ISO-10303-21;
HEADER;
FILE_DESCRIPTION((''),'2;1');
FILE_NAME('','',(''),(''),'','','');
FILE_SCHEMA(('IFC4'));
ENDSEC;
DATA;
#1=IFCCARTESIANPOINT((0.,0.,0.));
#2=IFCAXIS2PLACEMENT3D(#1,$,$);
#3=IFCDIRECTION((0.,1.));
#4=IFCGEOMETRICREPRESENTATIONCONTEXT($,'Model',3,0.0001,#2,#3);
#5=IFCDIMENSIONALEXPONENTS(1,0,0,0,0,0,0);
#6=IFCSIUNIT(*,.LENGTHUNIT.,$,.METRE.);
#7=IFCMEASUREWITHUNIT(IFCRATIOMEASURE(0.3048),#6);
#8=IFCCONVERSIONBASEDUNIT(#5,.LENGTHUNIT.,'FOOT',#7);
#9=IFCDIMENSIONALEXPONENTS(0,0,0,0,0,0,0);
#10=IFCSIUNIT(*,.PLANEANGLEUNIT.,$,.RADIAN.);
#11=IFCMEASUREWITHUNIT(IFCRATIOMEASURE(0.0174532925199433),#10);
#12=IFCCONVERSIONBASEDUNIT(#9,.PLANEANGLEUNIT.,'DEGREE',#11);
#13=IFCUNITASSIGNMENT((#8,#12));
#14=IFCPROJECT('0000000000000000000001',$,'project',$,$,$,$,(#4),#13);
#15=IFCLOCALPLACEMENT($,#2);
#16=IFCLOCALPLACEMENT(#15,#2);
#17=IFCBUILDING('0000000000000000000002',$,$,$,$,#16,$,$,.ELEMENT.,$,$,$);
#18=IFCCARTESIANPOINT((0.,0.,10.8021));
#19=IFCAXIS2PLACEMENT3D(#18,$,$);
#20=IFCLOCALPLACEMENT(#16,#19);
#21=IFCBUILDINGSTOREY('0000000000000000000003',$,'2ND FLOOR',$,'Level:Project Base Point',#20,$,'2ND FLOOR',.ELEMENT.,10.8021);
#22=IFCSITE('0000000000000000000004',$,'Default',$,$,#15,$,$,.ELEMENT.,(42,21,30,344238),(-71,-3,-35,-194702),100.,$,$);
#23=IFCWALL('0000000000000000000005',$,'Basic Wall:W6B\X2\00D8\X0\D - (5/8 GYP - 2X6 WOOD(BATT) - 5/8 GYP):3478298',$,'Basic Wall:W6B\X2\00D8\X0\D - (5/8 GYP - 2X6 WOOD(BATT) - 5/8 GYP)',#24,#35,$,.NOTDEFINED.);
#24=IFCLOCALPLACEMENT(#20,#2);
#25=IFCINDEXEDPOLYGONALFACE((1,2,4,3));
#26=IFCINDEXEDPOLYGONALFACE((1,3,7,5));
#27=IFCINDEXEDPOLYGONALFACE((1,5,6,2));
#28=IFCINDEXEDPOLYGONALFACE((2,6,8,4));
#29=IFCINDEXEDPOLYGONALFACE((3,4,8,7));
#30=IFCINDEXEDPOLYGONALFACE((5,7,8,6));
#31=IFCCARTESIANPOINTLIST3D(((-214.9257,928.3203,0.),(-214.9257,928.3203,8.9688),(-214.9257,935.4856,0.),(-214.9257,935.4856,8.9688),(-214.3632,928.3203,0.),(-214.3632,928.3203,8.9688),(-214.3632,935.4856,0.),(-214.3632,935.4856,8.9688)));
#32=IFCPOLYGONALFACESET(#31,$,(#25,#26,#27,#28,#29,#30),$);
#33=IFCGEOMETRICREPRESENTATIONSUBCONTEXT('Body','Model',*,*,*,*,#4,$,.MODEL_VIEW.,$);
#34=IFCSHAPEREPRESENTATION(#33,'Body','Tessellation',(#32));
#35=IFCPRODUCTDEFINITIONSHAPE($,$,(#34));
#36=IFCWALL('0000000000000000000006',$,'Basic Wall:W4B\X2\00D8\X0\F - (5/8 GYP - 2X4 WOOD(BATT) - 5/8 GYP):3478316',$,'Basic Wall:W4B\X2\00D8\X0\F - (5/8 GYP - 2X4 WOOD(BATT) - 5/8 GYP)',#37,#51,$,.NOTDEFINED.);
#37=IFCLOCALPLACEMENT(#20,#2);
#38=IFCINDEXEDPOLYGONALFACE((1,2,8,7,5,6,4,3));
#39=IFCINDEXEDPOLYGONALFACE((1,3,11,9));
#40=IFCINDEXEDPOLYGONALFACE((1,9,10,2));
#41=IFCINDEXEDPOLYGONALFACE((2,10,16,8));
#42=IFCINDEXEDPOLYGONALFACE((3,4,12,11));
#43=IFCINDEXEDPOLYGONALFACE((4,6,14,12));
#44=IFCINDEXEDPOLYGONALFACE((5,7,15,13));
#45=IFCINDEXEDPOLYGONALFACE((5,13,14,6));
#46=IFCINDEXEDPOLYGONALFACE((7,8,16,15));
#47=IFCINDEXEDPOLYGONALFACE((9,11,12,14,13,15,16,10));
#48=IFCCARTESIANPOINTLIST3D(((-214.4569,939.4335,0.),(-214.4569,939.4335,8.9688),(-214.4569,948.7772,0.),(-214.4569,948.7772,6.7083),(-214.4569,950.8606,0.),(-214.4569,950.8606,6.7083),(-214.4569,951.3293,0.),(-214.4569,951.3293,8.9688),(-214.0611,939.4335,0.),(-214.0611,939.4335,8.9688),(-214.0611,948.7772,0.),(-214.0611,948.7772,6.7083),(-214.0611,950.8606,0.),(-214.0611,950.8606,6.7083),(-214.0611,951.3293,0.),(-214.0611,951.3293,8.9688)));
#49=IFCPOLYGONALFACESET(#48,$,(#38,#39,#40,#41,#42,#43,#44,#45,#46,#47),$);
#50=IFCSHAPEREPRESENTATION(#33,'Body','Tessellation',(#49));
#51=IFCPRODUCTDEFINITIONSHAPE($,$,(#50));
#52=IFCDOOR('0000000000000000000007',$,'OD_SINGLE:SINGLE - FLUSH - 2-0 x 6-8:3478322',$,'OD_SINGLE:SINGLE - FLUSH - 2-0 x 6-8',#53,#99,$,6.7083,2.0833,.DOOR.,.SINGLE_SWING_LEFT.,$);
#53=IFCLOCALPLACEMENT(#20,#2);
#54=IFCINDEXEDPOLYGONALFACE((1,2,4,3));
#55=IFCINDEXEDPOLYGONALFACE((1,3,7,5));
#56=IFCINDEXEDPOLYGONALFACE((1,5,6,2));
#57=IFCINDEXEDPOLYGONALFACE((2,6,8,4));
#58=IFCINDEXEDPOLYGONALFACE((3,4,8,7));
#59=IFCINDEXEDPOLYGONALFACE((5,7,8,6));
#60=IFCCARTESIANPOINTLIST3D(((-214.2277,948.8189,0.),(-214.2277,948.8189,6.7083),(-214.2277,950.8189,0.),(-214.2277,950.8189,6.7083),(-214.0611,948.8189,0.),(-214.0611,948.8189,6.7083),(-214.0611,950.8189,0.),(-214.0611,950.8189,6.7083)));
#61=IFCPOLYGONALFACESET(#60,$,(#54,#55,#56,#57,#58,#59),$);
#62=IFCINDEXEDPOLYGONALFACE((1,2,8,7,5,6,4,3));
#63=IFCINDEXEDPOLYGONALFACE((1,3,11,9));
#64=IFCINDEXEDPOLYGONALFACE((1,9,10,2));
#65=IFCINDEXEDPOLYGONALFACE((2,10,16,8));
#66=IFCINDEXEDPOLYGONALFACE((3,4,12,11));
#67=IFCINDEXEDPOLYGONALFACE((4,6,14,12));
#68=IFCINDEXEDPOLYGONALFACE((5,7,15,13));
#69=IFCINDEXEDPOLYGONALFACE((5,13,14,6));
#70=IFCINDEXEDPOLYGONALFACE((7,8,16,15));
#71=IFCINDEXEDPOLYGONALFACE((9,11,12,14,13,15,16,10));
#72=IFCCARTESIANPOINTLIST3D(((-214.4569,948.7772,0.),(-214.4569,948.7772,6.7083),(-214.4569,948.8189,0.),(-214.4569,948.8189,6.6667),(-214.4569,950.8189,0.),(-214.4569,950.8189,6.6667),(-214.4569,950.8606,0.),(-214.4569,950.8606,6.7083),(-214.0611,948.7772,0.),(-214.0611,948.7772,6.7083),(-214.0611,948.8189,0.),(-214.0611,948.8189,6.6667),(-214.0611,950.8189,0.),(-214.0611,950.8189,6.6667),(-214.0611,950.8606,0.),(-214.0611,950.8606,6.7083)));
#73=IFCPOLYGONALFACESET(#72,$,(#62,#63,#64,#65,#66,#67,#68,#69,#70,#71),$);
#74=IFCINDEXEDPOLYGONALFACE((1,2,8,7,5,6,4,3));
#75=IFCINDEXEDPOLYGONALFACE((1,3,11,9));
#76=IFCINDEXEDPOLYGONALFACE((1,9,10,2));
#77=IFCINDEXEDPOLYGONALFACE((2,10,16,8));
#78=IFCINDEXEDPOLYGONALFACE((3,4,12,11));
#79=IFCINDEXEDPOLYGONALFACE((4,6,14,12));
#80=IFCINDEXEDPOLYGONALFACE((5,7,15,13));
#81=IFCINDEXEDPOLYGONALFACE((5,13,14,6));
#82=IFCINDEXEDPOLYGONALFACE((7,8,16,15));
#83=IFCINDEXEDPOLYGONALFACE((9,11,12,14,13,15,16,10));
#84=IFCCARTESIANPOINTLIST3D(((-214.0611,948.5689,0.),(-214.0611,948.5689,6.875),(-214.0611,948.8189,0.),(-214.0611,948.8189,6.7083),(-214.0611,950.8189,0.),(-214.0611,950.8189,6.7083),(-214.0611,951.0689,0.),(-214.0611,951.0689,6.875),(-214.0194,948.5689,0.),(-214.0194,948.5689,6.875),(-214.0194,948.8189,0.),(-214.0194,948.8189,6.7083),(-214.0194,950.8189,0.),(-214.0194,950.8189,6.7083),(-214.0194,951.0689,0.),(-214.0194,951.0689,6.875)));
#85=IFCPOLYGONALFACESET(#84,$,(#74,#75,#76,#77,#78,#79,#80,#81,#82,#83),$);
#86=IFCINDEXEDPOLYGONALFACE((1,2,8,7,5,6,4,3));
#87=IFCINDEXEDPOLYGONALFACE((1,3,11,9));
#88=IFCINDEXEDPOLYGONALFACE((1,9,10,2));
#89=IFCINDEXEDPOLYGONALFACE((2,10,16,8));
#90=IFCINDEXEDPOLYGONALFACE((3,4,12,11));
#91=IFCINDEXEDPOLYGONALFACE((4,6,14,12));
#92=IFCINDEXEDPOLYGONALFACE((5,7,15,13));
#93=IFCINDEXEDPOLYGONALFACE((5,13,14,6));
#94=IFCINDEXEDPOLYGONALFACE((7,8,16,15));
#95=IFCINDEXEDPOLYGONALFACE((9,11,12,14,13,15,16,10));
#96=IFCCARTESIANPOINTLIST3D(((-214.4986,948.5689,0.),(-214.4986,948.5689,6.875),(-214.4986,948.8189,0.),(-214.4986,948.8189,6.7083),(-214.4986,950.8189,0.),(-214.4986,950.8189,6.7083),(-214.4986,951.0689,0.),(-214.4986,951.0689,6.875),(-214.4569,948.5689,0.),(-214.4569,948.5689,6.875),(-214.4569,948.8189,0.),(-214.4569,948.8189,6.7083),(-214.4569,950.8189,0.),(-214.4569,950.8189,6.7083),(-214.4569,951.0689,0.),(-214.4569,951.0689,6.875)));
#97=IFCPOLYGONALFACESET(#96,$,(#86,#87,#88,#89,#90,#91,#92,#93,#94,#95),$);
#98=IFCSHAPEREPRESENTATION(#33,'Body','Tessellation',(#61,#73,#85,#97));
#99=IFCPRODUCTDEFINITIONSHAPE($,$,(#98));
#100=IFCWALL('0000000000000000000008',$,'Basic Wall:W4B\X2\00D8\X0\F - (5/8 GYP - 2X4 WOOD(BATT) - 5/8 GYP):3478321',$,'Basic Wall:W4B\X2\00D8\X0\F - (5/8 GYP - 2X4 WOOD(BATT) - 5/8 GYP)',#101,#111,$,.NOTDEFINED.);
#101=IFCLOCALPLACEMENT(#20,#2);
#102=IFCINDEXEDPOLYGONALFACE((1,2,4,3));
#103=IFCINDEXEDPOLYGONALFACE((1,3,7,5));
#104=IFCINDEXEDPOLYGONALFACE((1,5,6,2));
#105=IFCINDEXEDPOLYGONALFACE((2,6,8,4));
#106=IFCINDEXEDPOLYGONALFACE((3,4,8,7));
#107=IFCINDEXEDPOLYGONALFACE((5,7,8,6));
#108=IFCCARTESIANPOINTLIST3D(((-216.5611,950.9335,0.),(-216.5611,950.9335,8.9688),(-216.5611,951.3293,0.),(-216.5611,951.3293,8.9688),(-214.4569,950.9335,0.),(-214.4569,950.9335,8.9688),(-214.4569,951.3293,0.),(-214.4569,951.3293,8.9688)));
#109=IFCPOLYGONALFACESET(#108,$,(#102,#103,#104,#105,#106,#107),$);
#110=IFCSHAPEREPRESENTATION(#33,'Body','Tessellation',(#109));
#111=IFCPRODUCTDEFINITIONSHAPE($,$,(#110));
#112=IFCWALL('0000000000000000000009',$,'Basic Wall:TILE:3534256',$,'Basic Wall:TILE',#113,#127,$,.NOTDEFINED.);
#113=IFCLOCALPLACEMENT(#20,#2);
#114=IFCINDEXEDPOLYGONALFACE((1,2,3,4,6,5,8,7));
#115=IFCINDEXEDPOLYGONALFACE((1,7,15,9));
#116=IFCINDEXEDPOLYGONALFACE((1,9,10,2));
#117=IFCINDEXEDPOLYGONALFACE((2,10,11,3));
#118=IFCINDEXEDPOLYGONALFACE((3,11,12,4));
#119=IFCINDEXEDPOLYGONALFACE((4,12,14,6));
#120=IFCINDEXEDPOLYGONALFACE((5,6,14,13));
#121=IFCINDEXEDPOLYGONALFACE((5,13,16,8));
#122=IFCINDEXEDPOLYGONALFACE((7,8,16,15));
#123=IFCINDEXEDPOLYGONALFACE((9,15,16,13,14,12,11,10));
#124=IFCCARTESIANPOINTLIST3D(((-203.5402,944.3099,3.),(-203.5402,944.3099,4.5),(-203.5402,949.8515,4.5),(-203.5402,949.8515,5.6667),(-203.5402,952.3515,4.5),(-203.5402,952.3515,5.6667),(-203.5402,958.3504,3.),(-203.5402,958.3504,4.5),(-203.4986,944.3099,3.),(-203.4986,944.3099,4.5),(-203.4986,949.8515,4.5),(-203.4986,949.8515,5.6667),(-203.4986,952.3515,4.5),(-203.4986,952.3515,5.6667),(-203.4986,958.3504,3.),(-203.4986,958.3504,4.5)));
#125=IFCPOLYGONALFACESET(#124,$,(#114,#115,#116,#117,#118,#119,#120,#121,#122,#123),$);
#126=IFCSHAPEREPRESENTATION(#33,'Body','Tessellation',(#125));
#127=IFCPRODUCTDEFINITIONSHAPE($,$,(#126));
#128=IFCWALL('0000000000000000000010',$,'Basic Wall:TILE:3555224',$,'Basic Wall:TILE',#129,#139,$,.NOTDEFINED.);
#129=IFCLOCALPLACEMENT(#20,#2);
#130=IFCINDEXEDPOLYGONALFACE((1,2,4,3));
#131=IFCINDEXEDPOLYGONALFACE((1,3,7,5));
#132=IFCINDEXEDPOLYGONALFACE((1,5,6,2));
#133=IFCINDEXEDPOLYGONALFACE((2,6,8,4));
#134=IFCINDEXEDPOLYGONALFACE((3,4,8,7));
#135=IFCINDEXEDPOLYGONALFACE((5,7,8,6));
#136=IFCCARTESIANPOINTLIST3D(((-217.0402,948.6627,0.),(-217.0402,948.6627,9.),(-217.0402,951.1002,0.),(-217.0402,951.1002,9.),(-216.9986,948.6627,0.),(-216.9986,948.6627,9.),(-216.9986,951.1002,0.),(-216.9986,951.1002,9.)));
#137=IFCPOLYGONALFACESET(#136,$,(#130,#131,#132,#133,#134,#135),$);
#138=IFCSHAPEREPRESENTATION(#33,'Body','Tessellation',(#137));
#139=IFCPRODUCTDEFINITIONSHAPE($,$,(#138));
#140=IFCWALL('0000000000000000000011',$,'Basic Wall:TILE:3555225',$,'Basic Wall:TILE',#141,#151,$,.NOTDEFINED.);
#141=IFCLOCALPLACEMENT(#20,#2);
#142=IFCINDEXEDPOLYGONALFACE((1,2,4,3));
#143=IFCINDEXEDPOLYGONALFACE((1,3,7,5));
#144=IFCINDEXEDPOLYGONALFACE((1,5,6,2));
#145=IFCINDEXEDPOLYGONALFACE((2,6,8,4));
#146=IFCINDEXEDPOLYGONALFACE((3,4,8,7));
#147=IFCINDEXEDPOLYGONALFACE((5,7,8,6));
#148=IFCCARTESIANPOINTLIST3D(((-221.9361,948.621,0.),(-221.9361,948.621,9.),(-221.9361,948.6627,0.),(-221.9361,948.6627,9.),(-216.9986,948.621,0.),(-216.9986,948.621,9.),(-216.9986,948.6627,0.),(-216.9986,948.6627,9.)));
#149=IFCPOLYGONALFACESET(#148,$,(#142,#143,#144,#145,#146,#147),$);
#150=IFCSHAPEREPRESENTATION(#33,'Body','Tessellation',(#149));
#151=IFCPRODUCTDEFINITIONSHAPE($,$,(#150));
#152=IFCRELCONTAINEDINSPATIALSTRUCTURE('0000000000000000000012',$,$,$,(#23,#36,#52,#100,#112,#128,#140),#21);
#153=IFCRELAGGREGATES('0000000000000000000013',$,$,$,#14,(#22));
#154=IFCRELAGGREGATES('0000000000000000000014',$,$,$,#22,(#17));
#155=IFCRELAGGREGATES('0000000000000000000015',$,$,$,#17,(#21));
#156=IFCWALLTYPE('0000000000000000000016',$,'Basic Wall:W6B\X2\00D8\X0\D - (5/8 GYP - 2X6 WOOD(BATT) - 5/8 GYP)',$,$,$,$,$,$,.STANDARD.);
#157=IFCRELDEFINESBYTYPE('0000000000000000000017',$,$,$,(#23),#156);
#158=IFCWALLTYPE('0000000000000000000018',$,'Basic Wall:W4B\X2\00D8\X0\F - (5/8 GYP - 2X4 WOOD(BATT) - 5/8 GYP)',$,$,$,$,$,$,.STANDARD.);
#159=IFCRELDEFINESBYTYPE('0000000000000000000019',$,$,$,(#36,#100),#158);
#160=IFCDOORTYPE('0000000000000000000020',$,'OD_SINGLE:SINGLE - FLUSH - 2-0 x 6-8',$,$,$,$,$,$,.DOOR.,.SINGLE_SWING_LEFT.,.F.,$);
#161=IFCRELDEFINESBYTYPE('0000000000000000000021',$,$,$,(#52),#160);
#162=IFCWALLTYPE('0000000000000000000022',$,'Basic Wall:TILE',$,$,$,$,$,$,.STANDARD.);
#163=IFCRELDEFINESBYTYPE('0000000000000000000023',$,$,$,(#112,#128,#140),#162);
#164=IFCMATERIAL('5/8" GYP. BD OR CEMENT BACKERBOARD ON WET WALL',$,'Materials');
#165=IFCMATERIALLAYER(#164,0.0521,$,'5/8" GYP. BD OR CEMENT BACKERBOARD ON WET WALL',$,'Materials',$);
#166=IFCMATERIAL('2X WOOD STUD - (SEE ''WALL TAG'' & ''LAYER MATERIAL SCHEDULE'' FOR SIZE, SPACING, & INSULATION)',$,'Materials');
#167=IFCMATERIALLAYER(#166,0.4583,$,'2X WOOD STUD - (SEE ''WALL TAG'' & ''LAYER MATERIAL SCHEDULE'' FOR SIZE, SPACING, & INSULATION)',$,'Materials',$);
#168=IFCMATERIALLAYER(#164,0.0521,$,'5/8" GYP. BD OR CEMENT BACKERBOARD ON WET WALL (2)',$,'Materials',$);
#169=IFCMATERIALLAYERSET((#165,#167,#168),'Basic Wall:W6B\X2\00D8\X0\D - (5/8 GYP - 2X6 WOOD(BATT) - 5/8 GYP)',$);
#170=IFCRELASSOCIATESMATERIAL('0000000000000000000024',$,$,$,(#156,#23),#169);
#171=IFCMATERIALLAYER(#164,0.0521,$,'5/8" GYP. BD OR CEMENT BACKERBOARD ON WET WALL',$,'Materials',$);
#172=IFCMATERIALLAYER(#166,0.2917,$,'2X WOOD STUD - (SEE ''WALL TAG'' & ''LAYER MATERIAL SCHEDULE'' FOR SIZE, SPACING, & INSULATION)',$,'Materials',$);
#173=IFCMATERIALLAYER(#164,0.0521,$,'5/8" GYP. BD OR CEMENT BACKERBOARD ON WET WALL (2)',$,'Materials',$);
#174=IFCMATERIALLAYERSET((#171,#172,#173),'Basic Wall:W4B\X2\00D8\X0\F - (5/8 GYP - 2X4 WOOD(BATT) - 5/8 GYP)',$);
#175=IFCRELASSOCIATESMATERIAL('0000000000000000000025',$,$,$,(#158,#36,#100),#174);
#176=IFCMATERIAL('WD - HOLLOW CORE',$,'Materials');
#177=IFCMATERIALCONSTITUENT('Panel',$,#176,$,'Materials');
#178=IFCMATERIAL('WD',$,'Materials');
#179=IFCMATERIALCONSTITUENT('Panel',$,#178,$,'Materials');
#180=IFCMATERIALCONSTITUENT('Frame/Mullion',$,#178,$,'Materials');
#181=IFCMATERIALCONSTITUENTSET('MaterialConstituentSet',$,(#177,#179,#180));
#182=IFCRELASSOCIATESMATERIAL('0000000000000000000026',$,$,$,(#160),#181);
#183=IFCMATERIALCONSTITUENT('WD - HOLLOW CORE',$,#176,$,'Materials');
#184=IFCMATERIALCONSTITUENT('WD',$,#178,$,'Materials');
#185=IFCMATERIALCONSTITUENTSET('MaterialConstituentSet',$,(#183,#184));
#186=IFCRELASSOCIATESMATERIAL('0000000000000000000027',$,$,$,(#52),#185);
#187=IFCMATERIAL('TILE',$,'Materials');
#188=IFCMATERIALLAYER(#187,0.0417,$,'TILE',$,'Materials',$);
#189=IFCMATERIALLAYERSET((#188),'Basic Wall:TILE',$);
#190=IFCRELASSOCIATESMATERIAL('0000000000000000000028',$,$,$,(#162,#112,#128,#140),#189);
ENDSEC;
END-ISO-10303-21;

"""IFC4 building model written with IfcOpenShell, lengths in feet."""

from ifc_helpers import new_model, entity, si_unit, converted_unit, direction, frame, frame_2d, origin, origin_2d_with_axis, place, context, subcontext, project, spatial, polyline, rectangle, outline, extrude, source, transform, mapped, material, layer, layer_set, layer_usage, constituent, constituent_set, type_object, type_shapes, element, fill, save


model = new_model("IFC4")

# Units and contexts
model_context = context("Model", 3, precision=0.0001, world=origin(), true_north=direction((0.0, 1.0)))
body_context = subcontext(model_context, "Body", "Model", "MODEL_VIEW")
ifc_project = project(units=[converted_unit("LENGTHUNIT", "FOOT", entity("IfcRatioMeasure", 0.3048), si_unit("LENGTHUNIT", "METRE"), dimensions=[1, 0, 0, 0, 0, 0, 0]), converted_unit("PLANEANGLEUNIT", "DEGREE", entity("IfcRatioMeasure", 0.0174532925199433), si_unit("PLANEANGLEUNIT", "RADIAN"), dimensions=[0, 0, 0, 0, 0, 0, 0])], contexts=[model_context])

# Site, building, storey
site_placement = place(None, origin())
site = spatial("IfcSite", under=ifc_project, at=site_placement, Name="Default", CompositionType="ELEMENT", RefLatitude=(42, 21, 30, 344238), RefLongitude=(-71, -3, -35, -194702), RefElevation=100.0)
building_placement = place(site_placement, origin())
building = spatial("IfcBuilding", under=site, at=building_placement, CompositionType="ELEMENT")
storey_placement = place(building_placement, frame((0.0, 0.0, 10.8021)))
storey = spatial("IfcBuildingStorey", under=building, at=storey_placement, Name="2ND FLOOR", ObjectType="Level:Project Base Point", LongName="2ND FLOOR", CompositionType="ELEMENT", Elevation=10.8021)

# Wall
ifc_material_1 = material(Name="5/8\" GYP. BD OR CEMENT BACKERBOARD ON WET WALL", Category="Materials")
ifc_layer_1 = layer(ifc_material_1, 0.0521, Name="5/8\" GYP. BD OR CEMENT BACKERBOARD ON WET WALL", Category="Materials")
ifc_material_2 = material(Name="2X WOOD STUD - (SEE 'WALL TAG' & 'LAYER MATERIAL SCHEDULE' FOR SIZE, SPACING, & INSULATION)", Category="Materials")
ifc_layer_2 = layer(ifc_material_2, 0.4583, Name="2X WOOD STUD - (SEE 'WALL TAG' & 'LAYER MATERIAL SCHEDULE' FOR SIZE, SPACING, & INSULATION)", Category="Materials")
ifc_layer_3 = layer(ifc_material_1, 0.0521, Name="5/8\" GYP. BD OR CEMENT BACKERBOARD ON WET WALL (2)", Category="Materials")
ifc_layer_set_1 = layer_set([ifc_layer_1, ifc_layer_2, ifc_layer_3], Name="Basic Wall:W6BØD - (5/8 GYP - 2X6 WOOD(BATT) - 5/8 GYP)")
ifc_layer_usage_1 = layer_usage(ifc_layer_set_1, "AXIS2", "POSITIVE", -0.2812)
wall_type_1 = type_object("IfcWallType", Name="Basic Wall:W6BØD - (5/8 GYP - 2X6 WOOD(BATT) - 5/8 GYP)", PredefinedType="STANDARD", material=ifc_layer_set_1)
wall_1_placement = place(storey_placement, frame((-214.6444, 928.3203, 0.0), z_axis=(0.0, 0.0, 1.0), x_axis=(0.0, 1.0, 0.0)))
element("IfcWall", 1, at=wall_1_placement, inside=storey, type_object=wall_type_1, material=ifc_layer_usage_1, Name="Basic Wall:W6BØD - (5/8 GYP - 2X6 WOOD(BATT) - 5/8 GYP):3478298", ObjectType="Basic Wall:W6BØD - (5/8 GYP - 2X6 WOOD(BATT) - 5/8 GYP)", PredefinedType="NOTDEFINED", context=body_context, shape_type="SweptSolid", body=[
    extrude(rectangle(XDim=7.1653, YDim=0.5625, at=frame_2d((3.5826, 0.0), x_axis=(-1.0, 0.0))), origin(), (0.0, 0.0, 1.0), 8.9688),
])

# Wall, opening, door
ifc_layer_4 = layer(ifc_material_1, 0.0521, Name="5/8\" GYP. BD OR CEMENT BACKERBOARD ON WET WALL", Category="Materials")
ifc_layer_5 = layer(ifc_material_2, 0.2917, Name="2X WOOD STUD - (SEE 'WALL TAG' & 'LAYER MATERIAL SCHEDULE' FOR SIZE, SPACING, & INSULATION)", Category="Materials")
ifc_layer_6 = layer(ifc_material_1, 0.0521, Name="5/8\" GYP. BD OR CEMENT BACKERBOARD ON WET WALL (2)", Category="Materials")
ifc_layer_set_2 = layer_set([ifc_layer_4, ifc_layer_5, ifc_layer_6], Name="Basic Wall:W4BØF - (5/8 GYP - 2X4 WOOD(BATT) - 5/8 GYP)")
wall_type_2 = type_object("IfcWallType", Name="Basic Wall:W4BØF - (5/8 GYP - 2X4 WOOD(BATT) - 5/8 GYP)", PredefinedType="STANDARD", material=ifc_layer_set_2)
ifc_material_3 = material(Name="WD - HOLLOW CORE", Category="Materials")
ifc_material_4 = material(Name="WD", Category="Materials")
ifc_layer_usage_2 = layer_usage(ifc_layer_set_2, "AXIS2", "POSITIVE", -0.1979)
wall_2_placement = place(storey_placement, frame((-214.259, 939.4335, 0.0), z_axis=(0.0, 0.0, 1.0), x_axis=(0.0, 1.0, 0.0)))
wall_2 = element("IfcWall", 2, at=wall_2_placement, inside=storey, type_object=wall_type_2, material=ifc_layer_usage_2, Name="Basic Wall:W4BØF - (5/8 GYP - 2X4 WOOD(BATT) - 5/8 GYP):3478316", ObjectType="Basic Wall:W4BØF - (5/8 GYP - 2X4 WOOD(BATT) - 5/8 GYP)", PredefinedType="NOTDEFINED", context=body_context, shape_type="SweptSolid", body=[
    extrude(rectangle(XDim=11.8958, YDim=0.3958, at=frame_2d((5.9479, 0.0), x_axis=(-1.0, 0.0))), origin(), (0.0, 0.0, 1.0), 8.9688),
])
opening_1_placement = place(wall_2_placement, frame((11.4271, 0.1979, 0.0)))
opening_1 = element("IfcOpeningElement", 3, at=opening_1_placement, cuts=wall_2, PredefinedType="OPENING", context=body_context, shape_type="SweptSolid", body=[
    extrude(rectangle(XDim=2.0833, YDim=6.7083, at=frame_2d((3.3542, 1.0417), x_axis=(0.0, -1.0))), frame((0.0, 0.0, 0.0), z_axis=(0.0, -1.0, 0.0), x_axis=(0.0, 0.0, 1.0)), (0.0, 0.0, 1.0), 0.3958),
])
ifc_constituent_1 = constituent(ifc_material_3, Name="WD - HOLLOW CORE", Category="Materials")
ifc_constituent_2 = constituent(ifc_material_4, Name="WD", Category="Materials")
ifc_constituent_set_1 = constituent_set(constituents=[ifc_constituent_1, ifc_constituent_2], Name="MaterialConstituentSet")
ifc_constituent_3 = constituent(ifc_material_3, Name="Panel", Category="Materials")
ifc_constituent_4 = constituent(ifc_material_4, Name="Panel", Category="Materials")
ifc_constituent_5 = constituent(ifc_material_4, Name="Frame/Mullion", Category="Materials")
ifc_constituent_set_2 = constituent_set(constituents=[ifc_constituent_3, ifc_constituent_4, ifc_constituent_5], Name="MaterialConstituentSet")
door_type_1 = type_object("IfcDoorType", Name="OD_SINGLE:SINGLE - FLUSH - 2-0 x 6-8", OperationType="SINGLE_SWING_LEFT", ParameterTakesPrecedence=False, PredefinedType="DOOR", material=ifc_constituent_set_2)
shared_shape_1 = source(origin(), body_context, "Body", "SweptSolid", [
    extrude(rectangle(XDim=2.0, YDim=0.1667, at=origin_2d_with_axis()), frame((1.0417, 0.3125, 0.0)), (0.0, 0.0, 1.0), 6.7083),
    extrude(outline(polyline([(-3.3646, -1.0417), (3.3438, -1.0417), (3.3438, -1.0), (-3.3229, -1.0), (-3.3229, 1.0), (3.3438, 1.0), (3.3438, 1.0417), (-3.3646, 1.0417), (-3.3646, -1.0417)])), frame((1.0417, 0.3958, 3.3438), z_axis=(0.0, -1.0, 0.0), x_axis=(0.0, 0.0, -1.0)), (0.0, 0.0, 1.0), 0.3958),
    extrude(outline(polyline([(-1.25, -3.4792), (1.25, -3.4792), (1.25, 3.3958), (1.0, 3.3958), (1.0, -3.3125), (-1.0, -3.3125), (-1.0, 3.3958), (-1.25, 3.3958), (-1.25, -3.4792)])), frame((1.0417, 0.4375, 3.3958), z_axis=(0.0, -1.0, 0.0), x_axis=(-1.0, 0.0, 0.0)), (0.0, 0.0, 1.0), 0.0417),
    extrude(outline(polyline([(-3.4792, -1.25), (3.3958, -1.25), (3.3958, -1.0), (-3.3125, -1.0), (-3.3125, 1.0), (3.3958, 1.0), (3.3958, 1.25), (-3.4792, 1.25), (-3.4792, -1.25)])), frame((1.0417, 0.0, 3.3958), z_axis=(0.0, -1.0, 0.0), x_axis=(0.0, 0.0, -1.0)), (0.0, 0.0, 1.0), 0.0417),
])
type_shapes(door_type_1, [shared_shape_1])
door_1_placement = place(opening_1_placement, frame((0.0, 0.0, 0.0), z_axis=(0.0, 0.0, 1.0), x_axis=(-1.0, 0.0, 0.0)))
door_1 = element("IfcDoor", 4, at=door_1_placement, inside=storey, type_object=door_type_1, material=ifc_constituent_set_1, Name="OD_SINGLE:SINGLE - FLUSH - 2-0 x 6-8:3478322", ObjectType="OD_SINGLE:SINGLE - FLUSH - 2-0 x 6-8", OperationType="SINGLE_SWING_LEFT", OverallHeight=6.7083, OverallWidth=2.0833, PredefinedType="DOOR", context=body_context, shape_type="MappedRepresentation", body=[
    mapped(shared_shape_1, transform((0.0, 0.0, 0.0), scale=1.0)),
])
fill(opening_1, door_1)

# Wall
ifc_layer_usage_3 = layer_usage(ifc_layer_set_2, "AXIS2", "NEGATIVE", 0.1979)
wall_3_placement = place(storey_placement, frame((-216.5611, 951.1314, 0.0)))
element("IfcWall", 5, at=wall_3_placement, inside=storey, type_object=wall_type_2, material=ifc_layer_usage_3, Name="Basic Wall:W4BØF - (5/8 GYP - 2X4 WOOD(BATT) - 5/8 GYP):3478321", ObjectType="Basic Wall:W4BØF - (5/8 GYP - 2X4 WOOD(BATT) - 5/8 GYP)", PredefinedType="NOTDEFINED", context=body_context, shape_type="SweptSolid", body=[
    extrude(rectangle(XDim=2.1042, YDim=0.3958, at=frame_2d((1.0521, 0.0), x_axis=(-1.0, 0.0))), origin(), (0.0, 0.0, 1.0), 8.9688),
])

# Wall, openings
ifc_material_5 = material(Name="TILE", Category="Materials")
ifc_layer_7 = layer(ifc_material_5, 0.0417, Name="TILE", Category="Materials")
ifc_layer_set_3 = layer_set([ifc_layer_7], Name="Basic Wall:TILE")
ifc_layer_usage_4 = layer_usage(ifc_layer_set_3, "AXIS2", "NEGATIVE", 0.0208)
wall_type_3 = type_object("IfcWallType", Name="Basic Wall:TILE", PredefinedType="STANDARD", material=ifc_layer_set_3)
wall_4_placement = place(storey_placement, frame((-203.5194, 958.3504, 3.0), z_axis=(0.0, 0.0, 1.0), x_axis=(0.0, -1.0, 0.0)))
wall_4 = element("IfcWall", 6, at=wall_4_placement, inside=storey, type_object=wall_type_3, material=ifc_layer_usage_4, Name="Basic Wall:TILE:3534256", ObjectType="Basic Wall:TILE", PredefinedType="NOTDEFINED", context=body_context, shape_type="SweptSolid", body=[
    extrude(rectangle(XDim=14.0406, YDim=0.0417, at=frame_2d((7.0203, 0.0), x_axis=(-1.0, 0.0))), origin(), (0.0, 0.0, 1.0), 2.6667),
])
opening_2_placement = place(wall_4_placement, origin())
element("IfcOpeningElement", 7, at=opening_2_placement, cuts=wall_4, PredefinedType="OPENING", context=body_context, shape_type="SweptSolid", body=[
    extrude(rectangle(XDim=1.1667, YDim=5.5417, at=frame_2d((0.0, 0.0), x_axis=(1.0, 0.0))), frame((11.2697, 0.0208, 2.0833), z_axis=(0.0, -1.0, 0.0), x_axis=(0.0, 0.0, 1.0)), (0.0, 0.0, 1.0), 0.0417),
])
opening_3_placement = place(wall_4_placement, origin())
element("IfcOpeningElement", 8, at=opening_3_placement, cuts=wall_4, PredefinedType="OPENING", context=body_context, shape_type="SweptSolid", body=[
    extrude(rectangle(XDim=1.1667, YDim=5.9989, at=frame_2d((0.0, 0.0), x_axis=(0.0, 1.0))), frame((2.9994, 0.0208, 2.0833), z_axis=(0.0, -1.0, 0.0), x_axis=(-1.0, 0.0, 0.0)), (0.0, 0.0, 1.0), 0.0417),
])

# Walls
ifc_layer_usage_5 = layer_usage(ifc_layer_set_3, "AXIS2", "NEGATIVE", 0.0208)
wall_5_placement = place(storey_placement, frame((-217.0194, 951.1002, 0.0), z_axis=(0.0, 0.0, 1.0), x_axis=(0.0, -1.0, 0.0)))
element("IfcWall", 9, at=wall_5_placement, inside=storey, type_object=wall_type_3, material=ifc_layer_usage_5, Name="Basic Wall:TILE:3555224", ObjectType="Basic Wall:TILE", PredefinedType="NOTDEFINED", context=body_context, shape_type="SweptSolid", body=[
    extrude(rectangle(XDim=2.4375, YDim=0.0417, at=frame_2d((1.2187, 0.0), x_axis=(-1.0, 0.0))), origin(), (0.0, 0.0, 1.0), 9.0),
])
ifc_layer_usage_6 = layer_usage(ifc_layer_set_3, "AXIS2", "NEGATIVE", 0.0208)
wall_6_placement = place(storey_placement, frame((-216.9986, 948.6418, 0.0), z_axis=(0.0, 0.0, 1.0), x_axis=(-1.0, 0.0, 0.0)))
element("IfcWall", 10, at=wall_6_placement, inside=storey, type_object=wall_type_3, material=ifc_layer_usage_6, Name="Basic Wall:TILE:3555225", ObjectType="Basic Wall:TILE", PredefinedType="NOTDEFINED", context=body_context, shape_type="SweptSolid", body=[
    extrude(rectangle(XDim=4.9375, YDim=0.0417, at=frame_2d((2.4688, 0.0), x_axis=(-1.0, 0.0))), origin(), (0.0, 0.0, 1.0), 9.0),
])

save(model, "model.ifc")
